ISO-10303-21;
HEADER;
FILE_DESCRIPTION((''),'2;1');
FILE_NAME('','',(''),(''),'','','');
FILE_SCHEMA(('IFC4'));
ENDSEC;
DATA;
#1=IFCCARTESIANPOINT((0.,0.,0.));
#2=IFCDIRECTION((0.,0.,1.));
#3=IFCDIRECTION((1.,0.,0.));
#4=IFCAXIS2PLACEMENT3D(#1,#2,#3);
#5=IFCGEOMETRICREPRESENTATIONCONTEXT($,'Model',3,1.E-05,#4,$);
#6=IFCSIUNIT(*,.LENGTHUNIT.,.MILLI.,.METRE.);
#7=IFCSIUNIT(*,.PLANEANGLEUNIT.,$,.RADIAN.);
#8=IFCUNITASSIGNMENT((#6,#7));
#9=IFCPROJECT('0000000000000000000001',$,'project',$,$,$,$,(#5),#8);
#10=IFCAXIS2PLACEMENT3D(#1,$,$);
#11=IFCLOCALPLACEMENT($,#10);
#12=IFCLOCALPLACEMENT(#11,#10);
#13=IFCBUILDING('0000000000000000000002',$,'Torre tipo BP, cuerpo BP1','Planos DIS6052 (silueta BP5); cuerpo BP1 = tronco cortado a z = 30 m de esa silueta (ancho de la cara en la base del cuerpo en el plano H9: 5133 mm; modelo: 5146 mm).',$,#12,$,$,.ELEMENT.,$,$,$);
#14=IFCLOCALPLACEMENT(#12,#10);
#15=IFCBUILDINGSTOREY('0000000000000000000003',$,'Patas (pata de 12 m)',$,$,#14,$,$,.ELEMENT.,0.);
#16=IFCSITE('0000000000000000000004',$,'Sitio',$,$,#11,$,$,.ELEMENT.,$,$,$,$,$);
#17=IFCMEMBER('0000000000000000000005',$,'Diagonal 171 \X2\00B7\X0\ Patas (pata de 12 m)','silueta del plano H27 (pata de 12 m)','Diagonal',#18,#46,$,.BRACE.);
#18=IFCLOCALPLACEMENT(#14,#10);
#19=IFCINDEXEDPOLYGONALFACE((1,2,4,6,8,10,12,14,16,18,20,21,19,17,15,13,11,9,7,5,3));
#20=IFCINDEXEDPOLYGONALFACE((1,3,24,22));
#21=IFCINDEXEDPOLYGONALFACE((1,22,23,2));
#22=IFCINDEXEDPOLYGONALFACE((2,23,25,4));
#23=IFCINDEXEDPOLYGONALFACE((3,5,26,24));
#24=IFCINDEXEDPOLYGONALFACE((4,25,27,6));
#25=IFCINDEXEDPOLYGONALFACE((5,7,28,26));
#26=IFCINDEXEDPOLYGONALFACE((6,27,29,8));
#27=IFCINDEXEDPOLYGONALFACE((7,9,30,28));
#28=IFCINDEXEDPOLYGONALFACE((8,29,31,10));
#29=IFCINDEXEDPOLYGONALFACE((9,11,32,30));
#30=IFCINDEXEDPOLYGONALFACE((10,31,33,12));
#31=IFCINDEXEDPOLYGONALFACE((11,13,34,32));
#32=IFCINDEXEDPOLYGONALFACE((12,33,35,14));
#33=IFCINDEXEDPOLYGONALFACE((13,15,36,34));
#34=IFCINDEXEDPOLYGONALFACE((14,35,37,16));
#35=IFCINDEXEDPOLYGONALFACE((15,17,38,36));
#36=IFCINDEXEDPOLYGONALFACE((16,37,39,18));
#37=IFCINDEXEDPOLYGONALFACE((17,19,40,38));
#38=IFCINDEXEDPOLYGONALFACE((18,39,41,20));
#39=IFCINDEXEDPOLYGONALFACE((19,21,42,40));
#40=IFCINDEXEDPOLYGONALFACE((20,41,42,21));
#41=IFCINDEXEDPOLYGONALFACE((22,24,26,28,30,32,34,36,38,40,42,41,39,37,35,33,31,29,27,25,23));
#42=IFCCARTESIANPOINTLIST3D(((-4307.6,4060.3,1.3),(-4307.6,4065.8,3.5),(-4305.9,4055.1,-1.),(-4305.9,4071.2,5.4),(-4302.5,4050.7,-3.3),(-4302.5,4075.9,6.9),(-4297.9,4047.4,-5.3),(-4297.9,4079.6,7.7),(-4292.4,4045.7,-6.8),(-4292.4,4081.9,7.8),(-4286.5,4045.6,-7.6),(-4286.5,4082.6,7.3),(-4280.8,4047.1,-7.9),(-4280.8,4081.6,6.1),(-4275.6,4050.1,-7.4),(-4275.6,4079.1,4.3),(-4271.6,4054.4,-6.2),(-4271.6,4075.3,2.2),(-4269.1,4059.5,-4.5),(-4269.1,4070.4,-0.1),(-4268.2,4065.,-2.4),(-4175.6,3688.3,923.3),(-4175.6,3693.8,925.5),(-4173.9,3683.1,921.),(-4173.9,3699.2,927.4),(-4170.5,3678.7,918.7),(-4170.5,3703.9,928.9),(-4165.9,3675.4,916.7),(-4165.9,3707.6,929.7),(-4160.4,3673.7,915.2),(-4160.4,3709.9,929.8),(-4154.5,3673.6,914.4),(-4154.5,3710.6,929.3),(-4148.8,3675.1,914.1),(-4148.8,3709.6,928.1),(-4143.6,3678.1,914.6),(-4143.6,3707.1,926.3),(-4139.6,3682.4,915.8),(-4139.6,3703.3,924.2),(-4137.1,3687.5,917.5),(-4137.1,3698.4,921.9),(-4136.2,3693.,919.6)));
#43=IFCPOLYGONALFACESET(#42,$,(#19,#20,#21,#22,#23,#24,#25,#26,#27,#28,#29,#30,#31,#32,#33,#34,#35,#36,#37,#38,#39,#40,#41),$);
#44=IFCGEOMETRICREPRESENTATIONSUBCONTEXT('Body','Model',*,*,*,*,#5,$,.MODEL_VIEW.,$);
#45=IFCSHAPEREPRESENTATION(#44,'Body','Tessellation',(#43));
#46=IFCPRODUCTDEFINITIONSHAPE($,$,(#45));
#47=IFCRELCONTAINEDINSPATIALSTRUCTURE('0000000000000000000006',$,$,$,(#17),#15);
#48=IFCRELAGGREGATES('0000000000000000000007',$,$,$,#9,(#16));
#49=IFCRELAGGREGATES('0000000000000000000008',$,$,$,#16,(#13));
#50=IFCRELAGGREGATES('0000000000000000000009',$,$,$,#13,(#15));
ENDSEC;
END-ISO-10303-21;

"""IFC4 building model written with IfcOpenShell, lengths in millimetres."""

from ifc_helpers import new_model, si_unit, frame, origin, origin_with_axes, place, context, subcontext, project, spatial, circle, extrude, element, save


model = new_model("IFC4")

# Units and contexts
model_context = context("Model", 3, precision=1e-05, world=origin_with_axes())
body_context = subcontext(model_context, "Body", "Model", "MODEL_VIEW")
ifc_project = project(units=[si_unit("LENGTHUNIT", "METRE", prefix="MILLI"), si_unit("PLANEANGLEUNIT", "RADIAN")], contexts=[model_context])

# Site, building, storey
site_placement = place(None, origin())
site = spatial("IfcSite", under=ifc_project, at=site_placement, Name="Sitio", CompositionType="ELEMENT")
building_placement = place(site_placement, origin())
building = spatial("IfcBuilding", under=site, at=building_placement, Name="Torre tipo BP, cuerpo BP1", Description="Planos DIS6052 (silueta BP5); cuerpo BP1 = tronco cortado a z = 30 m de esa silueta (ancho de la cara en la base del cuerpo en el plano H9: 5133 mm; modelo: 5146 mm).", CompositionType="ELEMENT")
storey_placement = place(building_placement, origin())
storey = spatial("IfcBuildingStorey", under=building, at=storey_placement, Name="Patas (pata de 12 m)", CompositionType="ELEMENT", Elevation=0.0)

# Member
member_1_placement = place(storey_placement, frame((-4288.0, 4064.0, 0.0), z_axis=(0.131613, -0.370909, 0.919296), x_axis=(0.991301, 0.049245, -0.122053)))
element("IfcMember", 1, at=member_1_placement, inside=storey, Name="Diagonal 171 · Patas (pata de 12 m)", Description="silueta del plano H27 (pata de 12 m)", ObjectType="Diagonal", PredefinedType="BRACE", context=body_context, shape_type="SweptSolid", body=[
    extrude(circle(Radius=20.0), None, (0.0, 0.0, 1.0), 1002.9),
])

save(model, "model.ifc")
